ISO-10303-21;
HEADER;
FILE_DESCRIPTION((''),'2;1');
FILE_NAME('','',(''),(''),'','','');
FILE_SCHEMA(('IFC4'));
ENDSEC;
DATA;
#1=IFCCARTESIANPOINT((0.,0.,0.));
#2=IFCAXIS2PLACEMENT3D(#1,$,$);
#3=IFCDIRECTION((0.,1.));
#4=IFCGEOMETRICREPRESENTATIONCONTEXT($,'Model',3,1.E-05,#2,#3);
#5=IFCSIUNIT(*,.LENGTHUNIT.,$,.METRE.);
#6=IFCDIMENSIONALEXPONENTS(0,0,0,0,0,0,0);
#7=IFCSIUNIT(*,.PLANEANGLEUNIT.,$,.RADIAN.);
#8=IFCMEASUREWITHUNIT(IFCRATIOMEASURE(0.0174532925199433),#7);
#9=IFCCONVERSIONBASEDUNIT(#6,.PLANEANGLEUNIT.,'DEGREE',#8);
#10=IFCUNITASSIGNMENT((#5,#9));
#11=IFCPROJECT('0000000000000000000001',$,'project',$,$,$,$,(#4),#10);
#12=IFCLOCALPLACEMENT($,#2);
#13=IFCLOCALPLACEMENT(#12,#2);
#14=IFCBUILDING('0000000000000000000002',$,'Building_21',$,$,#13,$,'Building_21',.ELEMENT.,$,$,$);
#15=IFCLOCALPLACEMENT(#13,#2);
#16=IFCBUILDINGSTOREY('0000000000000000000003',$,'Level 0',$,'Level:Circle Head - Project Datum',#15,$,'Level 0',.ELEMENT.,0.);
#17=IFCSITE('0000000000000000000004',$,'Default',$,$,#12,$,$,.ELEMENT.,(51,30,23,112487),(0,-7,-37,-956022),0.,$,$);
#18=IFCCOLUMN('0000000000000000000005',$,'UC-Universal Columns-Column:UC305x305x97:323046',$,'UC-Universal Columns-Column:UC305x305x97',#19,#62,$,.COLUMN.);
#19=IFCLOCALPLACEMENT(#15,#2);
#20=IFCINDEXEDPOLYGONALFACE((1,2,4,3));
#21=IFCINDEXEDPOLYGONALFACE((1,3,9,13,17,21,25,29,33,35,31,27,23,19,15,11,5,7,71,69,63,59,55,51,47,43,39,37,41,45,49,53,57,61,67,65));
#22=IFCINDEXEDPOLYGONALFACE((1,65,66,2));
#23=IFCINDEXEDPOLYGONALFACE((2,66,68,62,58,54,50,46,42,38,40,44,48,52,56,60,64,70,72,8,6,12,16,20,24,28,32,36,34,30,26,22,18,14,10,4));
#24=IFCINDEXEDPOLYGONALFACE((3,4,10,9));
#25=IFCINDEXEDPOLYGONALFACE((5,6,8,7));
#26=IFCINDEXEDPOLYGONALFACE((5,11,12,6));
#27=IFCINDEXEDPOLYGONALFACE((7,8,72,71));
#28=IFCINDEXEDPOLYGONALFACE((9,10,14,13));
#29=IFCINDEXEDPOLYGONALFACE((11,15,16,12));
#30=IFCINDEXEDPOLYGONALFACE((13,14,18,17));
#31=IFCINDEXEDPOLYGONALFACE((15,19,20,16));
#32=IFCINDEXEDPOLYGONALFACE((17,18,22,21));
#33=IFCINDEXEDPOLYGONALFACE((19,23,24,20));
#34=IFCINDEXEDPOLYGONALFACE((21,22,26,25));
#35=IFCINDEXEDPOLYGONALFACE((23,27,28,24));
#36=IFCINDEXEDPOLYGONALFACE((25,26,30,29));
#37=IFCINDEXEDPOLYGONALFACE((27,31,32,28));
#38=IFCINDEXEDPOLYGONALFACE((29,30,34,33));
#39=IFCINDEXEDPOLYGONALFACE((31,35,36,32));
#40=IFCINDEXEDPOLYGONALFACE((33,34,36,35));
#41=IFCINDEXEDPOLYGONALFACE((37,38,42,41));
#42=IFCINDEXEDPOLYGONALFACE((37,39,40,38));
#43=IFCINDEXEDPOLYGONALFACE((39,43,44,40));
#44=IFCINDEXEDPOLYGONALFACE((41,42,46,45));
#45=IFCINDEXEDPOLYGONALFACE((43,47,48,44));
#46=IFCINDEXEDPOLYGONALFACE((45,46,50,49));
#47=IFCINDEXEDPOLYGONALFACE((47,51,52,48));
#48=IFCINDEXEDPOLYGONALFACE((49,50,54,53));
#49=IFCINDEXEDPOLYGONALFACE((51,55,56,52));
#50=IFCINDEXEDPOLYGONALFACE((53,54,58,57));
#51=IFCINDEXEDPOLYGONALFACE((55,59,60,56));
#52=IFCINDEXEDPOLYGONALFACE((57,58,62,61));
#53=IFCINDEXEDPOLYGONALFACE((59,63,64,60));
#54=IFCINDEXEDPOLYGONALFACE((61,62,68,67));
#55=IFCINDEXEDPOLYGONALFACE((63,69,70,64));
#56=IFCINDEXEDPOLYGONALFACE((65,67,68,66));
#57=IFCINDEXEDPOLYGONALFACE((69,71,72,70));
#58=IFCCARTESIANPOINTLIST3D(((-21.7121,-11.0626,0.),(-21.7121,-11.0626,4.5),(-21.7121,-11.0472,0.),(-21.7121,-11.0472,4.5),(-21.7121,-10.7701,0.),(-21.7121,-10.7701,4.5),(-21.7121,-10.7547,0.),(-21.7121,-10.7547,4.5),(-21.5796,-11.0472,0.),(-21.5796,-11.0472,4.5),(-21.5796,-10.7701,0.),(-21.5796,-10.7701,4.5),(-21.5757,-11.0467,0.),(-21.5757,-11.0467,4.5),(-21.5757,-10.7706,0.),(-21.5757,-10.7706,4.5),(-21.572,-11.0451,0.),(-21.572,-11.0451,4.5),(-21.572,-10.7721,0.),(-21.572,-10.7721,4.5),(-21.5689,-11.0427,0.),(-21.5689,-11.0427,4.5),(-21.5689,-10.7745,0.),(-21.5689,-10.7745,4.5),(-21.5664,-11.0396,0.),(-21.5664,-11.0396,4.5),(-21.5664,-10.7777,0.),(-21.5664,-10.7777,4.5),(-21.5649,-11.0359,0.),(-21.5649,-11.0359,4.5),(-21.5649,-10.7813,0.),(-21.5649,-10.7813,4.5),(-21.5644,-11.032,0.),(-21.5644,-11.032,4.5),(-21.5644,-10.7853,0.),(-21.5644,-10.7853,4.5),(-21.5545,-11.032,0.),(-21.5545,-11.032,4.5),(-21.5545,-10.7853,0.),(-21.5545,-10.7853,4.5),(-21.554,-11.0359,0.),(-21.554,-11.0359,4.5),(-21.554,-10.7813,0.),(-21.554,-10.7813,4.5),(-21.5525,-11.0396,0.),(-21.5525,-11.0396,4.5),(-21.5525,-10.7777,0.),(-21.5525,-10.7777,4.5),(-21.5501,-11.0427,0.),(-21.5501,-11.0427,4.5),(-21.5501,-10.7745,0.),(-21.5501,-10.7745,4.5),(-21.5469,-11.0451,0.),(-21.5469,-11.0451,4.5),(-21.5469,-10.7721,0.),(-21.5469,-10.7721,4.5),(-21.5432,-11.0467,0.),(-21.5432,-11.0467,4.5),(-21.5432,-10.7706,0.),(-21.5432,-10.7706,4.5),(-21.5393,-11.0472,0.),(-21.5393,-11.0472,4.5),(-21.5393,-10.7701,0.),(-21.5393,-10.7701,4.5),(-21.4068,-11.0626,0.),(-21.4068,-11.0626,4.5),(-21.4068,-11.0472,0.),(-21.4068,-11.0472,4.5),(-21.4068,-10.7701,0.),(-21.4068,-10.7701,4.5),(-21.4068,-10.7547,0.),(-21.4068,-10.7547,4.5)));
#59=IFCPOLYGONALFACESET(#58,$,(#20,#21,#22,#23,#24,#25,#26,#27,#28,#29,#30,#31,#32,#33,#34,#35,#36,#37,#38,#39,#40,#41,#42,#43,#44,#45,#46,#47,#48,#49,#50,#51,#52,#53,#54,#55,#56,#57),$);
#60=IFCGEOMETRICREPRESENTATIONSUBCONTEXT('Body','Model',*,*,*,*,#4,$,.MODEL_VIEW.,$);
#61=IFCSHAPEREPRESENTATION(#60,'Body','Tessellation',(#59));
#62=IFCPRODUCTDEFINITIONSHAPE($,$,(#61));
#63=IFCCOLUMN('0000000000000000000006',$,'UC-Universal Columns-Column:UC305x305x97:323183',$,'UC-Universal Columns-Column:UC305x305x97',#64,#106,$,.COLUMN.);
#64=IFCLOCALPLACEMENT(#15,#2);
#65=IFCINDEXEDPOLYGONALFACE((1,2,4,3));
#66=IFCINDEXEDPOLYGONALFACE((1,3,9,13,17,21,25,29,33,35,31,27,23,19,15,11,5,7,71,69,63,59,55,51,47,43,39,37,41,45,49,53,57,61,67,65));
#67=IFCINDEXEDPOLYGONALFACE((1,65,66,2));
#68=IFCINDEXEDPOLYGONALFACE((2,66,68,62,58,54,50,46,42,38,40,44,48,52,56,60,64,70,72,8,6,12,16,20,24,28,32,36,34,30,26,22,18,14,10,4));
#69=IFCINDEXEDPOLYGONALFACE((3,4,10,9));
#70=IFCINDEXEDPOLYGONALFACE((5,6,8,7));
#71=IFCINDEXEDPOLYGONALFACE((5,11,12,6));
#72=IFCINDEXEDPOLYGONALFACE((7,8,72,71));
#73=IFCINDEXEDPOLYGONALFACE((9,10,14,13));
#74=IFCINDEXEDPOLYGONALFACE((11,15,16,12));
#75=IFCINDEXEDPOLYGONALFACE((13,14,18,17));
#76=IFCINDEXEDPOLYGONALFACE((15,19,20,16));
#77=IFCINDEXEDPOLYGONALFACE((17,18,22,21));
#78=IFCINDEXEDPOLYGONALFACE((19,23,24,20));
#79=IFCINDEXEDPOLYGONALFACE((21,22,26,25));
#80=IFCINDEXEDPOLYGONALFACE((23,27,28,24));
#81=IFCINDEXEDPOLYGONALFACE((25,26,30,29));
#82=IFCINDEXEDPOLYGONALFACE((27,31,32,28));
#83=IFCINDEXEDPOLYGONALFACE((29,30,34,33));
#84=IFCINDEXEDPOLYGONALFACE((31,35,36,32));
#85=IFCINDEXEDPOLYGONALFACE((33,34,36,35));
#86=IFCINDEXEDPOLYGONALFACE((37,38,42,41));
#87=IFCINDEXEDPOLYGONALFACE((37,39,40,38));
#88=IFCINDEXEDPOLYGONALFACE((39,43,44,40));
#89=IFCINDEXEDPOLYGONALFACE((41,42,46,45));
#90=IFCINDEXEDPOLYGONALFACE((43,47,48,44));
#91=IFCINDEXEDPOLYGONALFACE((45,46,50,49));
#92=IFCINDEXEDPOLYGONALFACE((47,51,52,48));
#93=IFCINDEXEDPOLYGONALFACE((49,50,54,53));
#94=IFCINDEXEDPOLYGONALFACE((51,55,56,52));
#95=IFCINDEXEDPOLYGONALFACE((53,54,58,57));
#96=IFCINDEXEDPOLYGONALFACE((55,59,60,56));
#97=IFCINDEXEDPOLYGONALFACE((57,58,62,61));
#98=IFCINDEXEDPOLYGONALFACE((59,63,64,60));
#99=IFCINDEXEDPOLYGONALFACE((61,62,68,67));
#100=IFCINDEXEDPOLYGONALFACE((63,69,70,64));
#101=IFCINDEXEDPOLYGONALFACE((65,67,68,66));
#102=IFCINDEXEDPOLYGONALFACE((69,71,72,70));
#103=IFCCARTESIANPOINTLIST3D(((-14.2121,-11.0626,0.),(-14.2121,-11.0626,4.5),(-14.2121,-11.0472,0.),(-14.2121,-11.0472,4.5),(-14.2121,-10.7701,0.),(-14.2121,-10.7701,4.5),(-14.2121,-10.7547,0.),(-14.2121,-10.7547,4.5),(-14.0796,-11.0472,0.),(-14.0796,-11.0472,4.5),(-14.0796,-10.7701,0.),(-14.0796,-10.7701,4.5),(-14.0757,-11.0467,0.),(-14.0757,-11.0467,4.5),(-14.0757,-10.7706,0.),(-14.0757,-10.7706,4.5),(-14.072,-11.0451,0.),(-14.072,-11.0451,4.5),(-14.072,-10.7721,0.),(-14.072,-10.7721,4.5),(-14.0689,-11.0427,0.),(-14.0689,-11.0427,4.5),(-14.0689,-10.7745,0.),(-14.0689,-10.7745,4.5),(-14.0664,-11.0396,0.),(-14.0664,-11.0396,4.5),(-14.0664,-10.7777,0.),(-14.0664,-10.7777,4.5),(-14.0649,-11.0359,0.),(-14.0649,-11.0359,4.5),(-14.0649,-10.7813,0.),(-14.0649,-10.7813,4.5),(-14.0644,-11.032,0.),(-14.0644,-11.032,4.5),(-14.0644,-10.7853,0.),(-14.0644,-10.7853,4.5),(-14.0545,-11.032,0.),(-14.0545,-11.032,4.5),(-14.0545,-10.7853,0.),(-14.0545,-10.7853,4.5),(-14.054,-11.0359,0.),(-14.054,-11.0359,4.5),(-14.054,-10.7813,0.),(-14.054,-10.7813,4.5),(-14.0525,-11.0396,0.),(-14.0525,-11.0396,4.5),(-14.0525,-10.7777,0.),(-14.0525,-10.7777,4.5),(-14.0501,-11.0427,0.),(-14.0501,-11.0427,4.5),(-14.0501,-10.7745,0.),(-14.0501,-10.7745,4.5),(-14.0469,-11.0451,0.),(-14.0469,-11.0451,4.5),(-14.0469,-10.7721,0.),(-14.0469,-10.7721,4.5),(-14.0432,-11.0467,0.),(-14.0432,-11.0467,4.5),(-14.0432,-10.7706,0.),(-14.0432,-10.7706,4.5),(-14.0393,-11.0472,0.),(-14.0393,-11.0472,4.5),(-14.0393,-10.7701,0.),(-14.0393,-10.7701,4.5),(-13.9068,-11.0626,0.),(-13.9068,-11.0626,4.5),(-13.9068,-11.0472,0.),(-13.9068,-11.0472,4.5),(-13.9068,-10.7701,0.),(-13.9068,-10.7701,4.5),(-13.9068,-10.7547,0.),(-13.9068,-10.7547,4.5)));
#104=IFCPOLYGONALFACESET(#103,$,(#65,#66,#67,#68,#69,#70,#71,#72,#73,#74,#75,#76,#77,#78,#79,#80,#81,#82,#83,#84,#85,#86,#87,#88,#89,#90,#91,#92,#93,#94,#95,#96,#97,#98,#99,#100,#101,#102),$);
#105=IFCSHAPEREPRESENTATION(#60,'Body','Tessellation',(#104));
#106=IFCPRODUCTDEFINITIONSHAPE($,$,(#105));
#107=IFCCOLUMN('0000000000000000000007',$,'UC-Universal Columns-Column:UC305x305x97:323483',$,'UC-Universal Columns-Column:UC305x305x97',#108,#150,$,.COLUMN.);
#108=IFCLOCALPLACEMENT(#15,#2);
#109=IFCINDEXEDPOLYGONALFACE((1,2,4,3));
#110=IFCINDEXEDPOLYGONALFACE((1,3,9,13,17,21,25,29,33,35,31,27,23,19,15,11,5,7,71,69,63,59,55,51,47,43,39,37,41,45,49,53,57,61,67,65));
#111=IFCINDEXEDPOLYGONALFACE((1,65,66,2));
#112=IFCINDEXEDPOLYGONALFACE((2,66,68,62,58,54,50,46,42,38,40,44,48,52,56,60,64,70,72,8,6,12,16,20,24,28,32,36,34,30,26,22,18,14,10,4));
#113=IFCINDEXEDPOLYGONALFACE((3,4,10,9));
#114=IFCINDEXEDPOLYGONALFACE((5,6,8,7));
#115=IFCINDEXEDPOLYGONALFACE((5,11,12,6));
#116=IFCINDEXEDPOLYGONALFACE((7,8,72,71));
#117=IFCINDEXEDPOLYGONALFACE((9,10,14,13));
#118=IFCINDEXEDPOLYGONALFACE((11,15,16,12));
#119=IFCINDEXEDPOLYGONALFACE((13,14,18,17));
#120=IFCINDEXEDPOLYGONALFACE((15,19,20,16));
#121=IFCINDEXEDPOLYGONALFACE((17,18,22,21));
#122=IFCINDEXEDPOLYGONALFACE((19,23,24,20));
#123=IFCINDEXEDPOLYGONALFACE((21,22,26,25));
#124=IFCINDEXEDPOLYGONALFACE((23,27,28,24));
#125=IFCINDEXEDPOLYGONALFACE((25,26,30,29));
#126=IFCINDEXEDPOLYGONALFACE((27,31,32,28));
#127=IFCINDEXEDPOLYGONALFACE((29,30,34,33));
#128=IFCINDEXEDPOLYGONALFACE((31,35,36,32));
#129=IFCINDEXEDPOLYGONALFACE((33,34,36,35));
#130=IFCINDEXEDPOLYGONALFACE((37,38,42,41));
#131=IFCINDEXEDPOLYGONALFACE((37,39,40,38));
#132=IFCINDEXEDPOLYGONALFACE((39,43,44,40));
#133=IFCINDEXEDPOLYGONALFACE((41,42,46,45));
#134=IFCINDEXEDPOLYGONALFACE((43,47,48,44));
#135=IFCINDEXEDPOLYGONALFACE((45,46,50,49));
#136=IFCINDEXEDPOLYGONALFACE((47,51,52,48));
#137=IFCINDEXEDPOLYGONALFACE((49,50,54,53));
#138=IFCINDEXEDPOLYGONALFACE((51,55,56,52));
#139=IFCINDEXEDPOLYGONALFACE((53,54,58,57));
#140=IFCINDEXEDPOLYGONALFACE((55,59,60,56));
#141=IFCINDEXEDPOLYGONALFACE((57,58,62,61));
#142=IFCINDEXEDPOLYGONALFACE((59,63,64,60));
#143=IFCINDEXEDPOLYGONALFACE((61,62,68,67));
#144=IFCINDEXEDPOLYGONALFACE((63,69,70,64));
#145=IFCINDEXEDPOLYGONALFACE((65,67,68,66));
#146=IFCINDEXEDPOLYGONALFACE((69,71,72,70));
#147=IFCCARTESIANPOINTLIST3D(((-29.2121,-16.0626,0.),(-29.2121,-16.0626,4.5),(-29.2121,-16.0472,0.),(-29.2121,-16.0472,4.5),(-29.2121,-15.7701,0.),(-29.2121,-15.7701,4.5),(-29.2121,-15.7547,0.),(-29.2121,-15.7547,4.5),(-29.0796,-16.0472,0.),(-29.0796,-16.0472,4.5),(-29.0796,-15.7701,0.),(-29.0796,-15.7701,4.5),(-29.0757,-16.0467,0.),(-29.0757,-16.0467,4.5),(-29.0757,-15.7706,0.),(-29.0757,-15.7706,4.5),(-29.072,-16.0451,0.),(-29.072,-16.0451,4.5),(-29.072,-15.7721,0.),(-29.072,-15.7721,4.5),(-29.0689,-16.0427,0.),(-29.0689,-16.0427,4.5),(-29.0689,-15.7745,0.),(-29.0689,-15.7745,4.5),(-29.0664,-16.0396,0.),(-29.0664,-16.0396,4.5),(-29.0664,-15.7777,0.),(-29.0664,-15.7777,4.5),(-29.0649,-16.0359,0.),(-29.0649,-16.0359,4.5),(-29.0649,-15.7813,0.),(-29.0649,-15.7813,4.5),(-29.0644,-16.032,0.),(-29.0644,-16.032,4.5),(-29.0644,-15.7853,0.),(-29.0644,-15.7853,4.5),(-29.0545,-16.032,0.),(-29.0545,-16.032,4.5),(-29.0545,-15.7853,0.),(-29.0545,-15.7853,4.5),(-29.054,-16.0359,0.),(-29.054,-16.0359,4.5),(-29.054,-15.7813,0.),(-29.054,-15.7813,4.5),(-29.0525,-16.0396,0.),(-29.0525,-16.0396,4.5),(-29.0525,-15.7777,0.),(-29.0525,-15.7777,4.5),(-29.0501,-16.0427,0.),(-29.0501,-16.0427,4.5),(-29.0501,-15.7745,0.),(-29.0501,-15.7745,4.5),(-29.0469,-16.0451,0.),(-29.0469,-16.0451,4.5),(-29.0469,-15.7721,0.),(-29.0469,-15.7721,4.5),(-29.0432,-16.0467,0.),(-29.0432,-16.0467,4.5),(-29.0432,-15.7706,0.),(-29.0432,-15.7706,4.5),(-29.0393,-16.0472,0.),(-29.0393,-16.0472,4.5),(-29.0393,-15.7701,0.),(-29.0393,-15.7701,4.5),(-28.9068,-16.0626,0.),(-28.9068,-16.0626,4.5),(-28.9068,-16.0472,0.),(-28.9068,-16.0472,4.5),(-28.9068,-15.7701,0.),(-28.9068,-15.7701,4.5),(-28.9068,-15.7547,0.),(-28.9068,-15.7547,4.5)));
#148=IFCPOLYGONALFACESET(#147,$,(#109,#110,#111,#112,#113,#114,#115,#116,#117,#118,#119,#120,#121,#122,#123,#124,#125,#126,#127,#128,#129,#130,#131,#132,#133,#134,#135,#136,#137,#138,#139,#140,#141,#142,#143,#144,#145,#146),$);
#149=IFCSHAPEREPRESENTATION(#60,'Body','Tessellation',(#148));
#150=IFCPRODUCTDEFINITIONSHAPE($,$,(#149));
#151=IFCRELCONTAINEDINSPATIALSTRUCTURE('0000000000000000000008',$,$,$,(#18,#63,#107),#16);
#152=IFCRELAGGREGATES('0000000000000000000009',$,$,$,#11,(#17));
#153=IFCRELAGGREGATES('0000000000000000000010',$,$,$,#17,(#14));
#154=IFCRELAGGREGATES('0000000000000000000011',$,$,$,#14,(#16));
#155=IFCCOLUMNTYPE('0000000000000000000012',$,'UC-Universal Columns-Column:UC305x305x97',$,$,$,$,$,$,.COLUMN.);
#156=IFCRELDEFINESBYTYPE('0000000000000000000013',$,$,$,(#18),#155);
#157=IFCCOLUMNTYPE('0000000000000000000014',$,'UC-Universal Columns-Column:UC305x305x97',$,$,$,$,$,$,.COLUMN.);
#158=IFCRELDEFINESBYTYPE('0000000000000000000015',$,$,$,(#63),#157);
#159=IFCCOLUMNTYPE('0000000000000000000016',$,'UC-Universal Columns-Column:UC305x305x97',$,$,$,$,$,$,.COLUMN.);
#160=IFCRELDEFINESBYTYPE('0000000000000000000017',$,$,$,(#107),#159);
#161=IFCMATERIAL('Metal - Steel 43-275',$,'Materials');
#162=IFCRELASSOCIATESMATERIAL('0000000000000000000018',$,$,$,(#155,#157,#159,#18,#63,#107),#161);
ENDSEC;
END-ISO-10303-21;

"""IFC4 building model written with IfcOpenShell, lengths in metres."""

from ifc_helpers import new_model, entity, si_unit, converted_unit, direction, frame, frame_2d, origin, place, context, subcontext, project, spatial, polyline, circle_curve, parameter, trimmed, segment, composite_curve, i_section, outline, extrude, source, transform, mapped, material, material_profile, profile_set, profile_usage, type_object, type_shapes, element, save


model = new_model("IFC4")

# Units and contexts
model_context = context("Model", 3, precision=1e-05, world=origin(), true_north=direction((0.0, 1.0)))
body_context = subcontext(model_context, "Body", "Model", "MODEL_VIEW")
ifc_project = project(units=[si_unit("LENGTHUNIT", "METRE"), converted_unit("PLANEANGLEUNIT", "DEGREE", entity("IfcRatioMeasure", 0.0174532925199433), si_unit("PLANEANGLEUNIT", "RADIAN"), dimensions=[0, 0, 0, 0, 0, 0, 0])], contexts=[model_context])

# Site, building, storey
site_placement = place(None, origin())
site = spatial("IfcSite", under=ifc_project, at=site_placement, Name="Default", CompositionType="ELEMENT", RefLatitude=(51, 30, 23, 112487), RefLongitude=(0, -7, -37, -956022), RefElevation=0.0)
building_placement = place(site_placement, origin())
building = spatial("IfcBuilding", under=site, at=building_placement, Name="Building_21", LongName="Building_21", CompositionType="ELEMENT")
storey_placement = place(building_placement, origin())
storey = spatial("IfcBuildingStorey", under=building, at=storey_placement, Name="Level 0", ObjectType="Level:Circle Head - Project Datum", LongName="Level 0", CompositionType="ELEMENT", Elevation=0.0)

# Columns
ifc_material_1 = material(Name="Metal - Steel 43-275", Category="Materials")
ifc_material_profile_1 = material_profile(ifc_material_1, outline(composite_curve([segment(polyline([(-0.1527, 0.154, 0.0), (0.1527, 0.154, 0.0)]), True, "CONTINUOUS"), segment(polyline([(0.1527, 0.154, 0.0), (0.1527, 0.1386, 0.0)]), True, "CONTINUOUS"), segment(polyline([(0.1527, 0.1386, 0.0), (0.0201, 0.1386, 0.0)]), True, "CONTINUOUS"), segment(trimmed(circle_curve(frame((0.0201, 0.1234, 0.0)), 0.0152), [parameter(90.0)], [parameter(180.0)], True, "PARAMETER"), True, "CONTINUOUS"), segment(polyline([(0.0049, 0.1234, 0.0), (0.0049, -0.1234, 0.0)]), True, "CONTINUOUS"), segment(trimmed(circle_curve(frame((0.0201, -0.1234, 0.0)), 0.0152), [parameter(180.0)], [parameter(270.0)], True, "PARAMETER"), True, "CONTINUOUS"), segment(polyline([(0.0201, -0.1386, 0.0), (0.1527, -0.1386, 0.0)]), True, "CONTINUOUS"), segment(polyline([(0.1527, -0.1386, 0.0), (0.1527, -0.154, 0.0)]), True, "CONTINUOUS"), segment(polyline([(0.1527, -0.154, 0.0), (-0.1527, -0.154, 0.0)]), True, "CONTINUOUS"), segment(polyline([(-0.1527, -0.154, 0.0), (-0.1527, -0.1386, 0.0)]), True, "CONTINUOUS"), segment(polyline([(-0.1527, -0.1386, 0.0), (-0.0201, -0.1386, 0.0)]), True, "CONTINUOUS"), segment(trimmed(circle_curve(frame((-0.0201, -0.1234, 0.0)), 0.0152), [parameter(270.0)], [parameter(0.0)], True, "PARAMETER"), True, "CONTINUOUS"), segment(polyline([(-0.0049, -0.1234, 0.0), (-0.005, 0.1234, 0.0)]), True, "CONTINUOUS"), segment(trimmed(circle_curve(frame((-0.0201, 0.1234, 0.0)), 0.0152), [parameter(0.0)], [parameter(90.0)], True, "PARAMETER"), True, "CONTINUOUS"), segment(polyline([(-0.0201, 0.1386, 0.0), (-0.1527, 0.1386, 0.0)]), True, "CONTINUOUS"), segment(polyline([(-0.1527, 0.1386, 0.0), (-0.1527, 0.154, 0.0)]), True, "CONTINUOUS")], self_intersect=False), kind="CURVE"), Name="UC305x305x97")
ifc_material_profile_2 = material_profile(ifc_material_1, outline(composite_curve([segment(polyline([(0.1527, 0.154, 0.0), (0.1527, 0.1386, 0.0)]), True, "CONTINUOUS"), segment(polyline([(0.1527, 0.1386, 0.0), (0.0049, 0.1386, 0.0)]), True, "CONTINUOUS"), segment(polyline([(0.0049, 0.1386, 0.0), (0.0049, -0.1386, 0.0)]), True, "CONTINUOUS"), segment(polyline([(0.0049, -0.1386, 0.0), (0.1527, -0.1386, 0.0)]), True, "CONTINUOUS"), segment(polyline([(0.1527, -0.1386, 0.0), (0.1527, -0.154, 0.0)]), True, "CONTINUOUS"), segment(polyline([(0.1527, -0.154, 0.0), (-0.1527, -0.154, 0.0)]), True, "CONTINUOUS"), segment(polyline([(-0.1527, -0.154, 0.0), (-0.1527, -0.1386, 0.0)]), True, "CONTINUOUS"), segment(polyline([(-0.1527, -0.1386, 0.0), (-0.005, -0.1386, 0.0)]), True, "CONTINUOUS"), segment(polyline([(-0.005, -0.1386, 0.0), (-0.005, 0.1386, 0.0)]), True, "CONTINUOUS"), segment(polyline([(-0.005, 0.1386, 0.0), (-0.1527, 0.1386, 0.0)]), True, "CONTINUOUS"), segment(polyline([(-0.1527, 0.1386, 0.0), (-0.1527, 0.154, 0.0)]), True, "CONTINUOUS"), segment(polyline([(-0.1527, 0.154, 0.0), (0.1527, 0.154, 0.0)]), True, "CONTINUOUS")], self_intersect=False), kind="CURVE"), Name="UC305x305x97")
ifc_profile_set = profile_set([ifc_material_profile_1, ifc_material_profile_2], Name="UC305x305x97")
ifc_profile_usage_1 = profile_usage(ifc_profile_set)
column_type_1 = type_object("IfcColumnType", Name="UC-Universal Columns-Column:UC305x305x97", PredefinedType="COLUMN", material=ifc_profile_set)
shared_shape_1 = source(origin(), body_context, "Body", "SweptSolid", [
    extrude(i_section(OverallWidth=0.3053, OverallDepth=0.3079, WebThickness=0.0099, FlangeThickness=0.0154, FilletRadius=0.0152, at=frame_2d((0.0, 0.0), x_axis=(0.0, 1.0))), frame((-21.5595, -10.9086, 0.0), z_axis=(0.0, 0.0, 1.0), x_axis=(0.0, -1.0, 0.0)), (0.0, 0.0, 1.0), 4.5),
])
type_shapes(column_type_1, [shared_shape_1])
column_1_placement = place(storey_placement, origin())
element("IfcColumn", 1, at=column_1_placement, inside=storey, type_object=column_type_1, material=ifc_profile_usage_1, Name="UC-Universal Columns-Column:UC305x305x97:323046", ObjectType="UC-Universal Columns-Column:UC305x305x97", PredefinedType="COLUMN", context=body_context, shape_type="MappedRepresentation", body=[
    mapped(shared_shape_1, transform((0.0, 0.0, 0.0), scale=1.0)),
])
ifc_profile_usage_2 = profile_usage(ifc_profile_set)
column_type_2 = type_object("IfcColumnType", Name="UC-Universal Columns-Column:UC305x305x97", PredefinedType="COLUMN", material=ifc_profile_set)
shared_shape_2 = source(origin(), body_context, "Body", "SweptSolid", [
    extrude(i_section(OverallWidth=0.3053, OverallDepth=0.3079, WebThickness=0.0099, FlangeThickness=0.0154, FilletRadius=0.0152, at=frame_2d((0.0, 0.0), x_axis=(0.0, 1.0))), frame((-14.0595, -10.9086, 0.0), z_axis=(0.0, 0.0, 1.0), x_axis=(0.0, -1.0, 0.0)), (0.0, 0.0, 1.0), 4.5),
])
type_shapes(column_type_2, [shared_shape_2])
column_2_placement = place(storey_placement, origin())
element("IfcColumn", 2, at=column_2_placement, inside=storey, type_object=column_type_2, material=ifc_profile_usage_2, Name="UC-Universal Columns-Column:UC305x305x97:323183", ObjectType="UC-Universal Columns-Column:UC305x305x97", PredefinedType="COLUMN", context=body_context, shape_type="MappedRepresentation", body=[
    mapped(shared_shape_2, transform((0.0, 0.0, 0.0), scale=1.0)),
])
ifc_profile_usage_3 = profile_usage(ifc_profile_set)
column_type_3 = type_object("IfcColumnType", Name="UC-Universal Columns-Column:UC305x305x97", PredefinedType="COLUMN", material=ifc_profile_set)
shared_shape_3 = source(origin(), body_context, "Body", "SweptSolid", [
    extrude(i_section(OverallWidth=0.3053, OverallDepth=0.3079, WebThickness=0.0099, FlangeThickness=0.0154, FilletRadius=0.0152, at=frame_2d((0.0, 0.0), x_axis=(0.0, 1.0))), frame((-29.0595, -15.9086, 0.0), z_axis=(0.0, 0.0, 1.0), x_axis=(0.0, -1.0, 0.0)), (0.0, 0.0, 1.0), 4.5),
])
type_shapes(column_type_3, [shared_shape_3])
column_3_placement = place(storey_placement, origin())
element("IfcColumn", 3, at=column_3_placement, inside=storey, type_object=column_type_3, material=ifc_profile_usage_3, Name="UC-Universal Columns-Column:UC305x305x97:323483", ObjectType="UC-Universal Columns-Column:UC305x305x97", PredefinedType="COLUMN", context=body_context, shape_type="MappedRepresentation", body=[
    mapped(shared_shape_3, transform((0.0, 0.0, 0.0), scale=1.0)),
])

save(model, "model.ifc")
